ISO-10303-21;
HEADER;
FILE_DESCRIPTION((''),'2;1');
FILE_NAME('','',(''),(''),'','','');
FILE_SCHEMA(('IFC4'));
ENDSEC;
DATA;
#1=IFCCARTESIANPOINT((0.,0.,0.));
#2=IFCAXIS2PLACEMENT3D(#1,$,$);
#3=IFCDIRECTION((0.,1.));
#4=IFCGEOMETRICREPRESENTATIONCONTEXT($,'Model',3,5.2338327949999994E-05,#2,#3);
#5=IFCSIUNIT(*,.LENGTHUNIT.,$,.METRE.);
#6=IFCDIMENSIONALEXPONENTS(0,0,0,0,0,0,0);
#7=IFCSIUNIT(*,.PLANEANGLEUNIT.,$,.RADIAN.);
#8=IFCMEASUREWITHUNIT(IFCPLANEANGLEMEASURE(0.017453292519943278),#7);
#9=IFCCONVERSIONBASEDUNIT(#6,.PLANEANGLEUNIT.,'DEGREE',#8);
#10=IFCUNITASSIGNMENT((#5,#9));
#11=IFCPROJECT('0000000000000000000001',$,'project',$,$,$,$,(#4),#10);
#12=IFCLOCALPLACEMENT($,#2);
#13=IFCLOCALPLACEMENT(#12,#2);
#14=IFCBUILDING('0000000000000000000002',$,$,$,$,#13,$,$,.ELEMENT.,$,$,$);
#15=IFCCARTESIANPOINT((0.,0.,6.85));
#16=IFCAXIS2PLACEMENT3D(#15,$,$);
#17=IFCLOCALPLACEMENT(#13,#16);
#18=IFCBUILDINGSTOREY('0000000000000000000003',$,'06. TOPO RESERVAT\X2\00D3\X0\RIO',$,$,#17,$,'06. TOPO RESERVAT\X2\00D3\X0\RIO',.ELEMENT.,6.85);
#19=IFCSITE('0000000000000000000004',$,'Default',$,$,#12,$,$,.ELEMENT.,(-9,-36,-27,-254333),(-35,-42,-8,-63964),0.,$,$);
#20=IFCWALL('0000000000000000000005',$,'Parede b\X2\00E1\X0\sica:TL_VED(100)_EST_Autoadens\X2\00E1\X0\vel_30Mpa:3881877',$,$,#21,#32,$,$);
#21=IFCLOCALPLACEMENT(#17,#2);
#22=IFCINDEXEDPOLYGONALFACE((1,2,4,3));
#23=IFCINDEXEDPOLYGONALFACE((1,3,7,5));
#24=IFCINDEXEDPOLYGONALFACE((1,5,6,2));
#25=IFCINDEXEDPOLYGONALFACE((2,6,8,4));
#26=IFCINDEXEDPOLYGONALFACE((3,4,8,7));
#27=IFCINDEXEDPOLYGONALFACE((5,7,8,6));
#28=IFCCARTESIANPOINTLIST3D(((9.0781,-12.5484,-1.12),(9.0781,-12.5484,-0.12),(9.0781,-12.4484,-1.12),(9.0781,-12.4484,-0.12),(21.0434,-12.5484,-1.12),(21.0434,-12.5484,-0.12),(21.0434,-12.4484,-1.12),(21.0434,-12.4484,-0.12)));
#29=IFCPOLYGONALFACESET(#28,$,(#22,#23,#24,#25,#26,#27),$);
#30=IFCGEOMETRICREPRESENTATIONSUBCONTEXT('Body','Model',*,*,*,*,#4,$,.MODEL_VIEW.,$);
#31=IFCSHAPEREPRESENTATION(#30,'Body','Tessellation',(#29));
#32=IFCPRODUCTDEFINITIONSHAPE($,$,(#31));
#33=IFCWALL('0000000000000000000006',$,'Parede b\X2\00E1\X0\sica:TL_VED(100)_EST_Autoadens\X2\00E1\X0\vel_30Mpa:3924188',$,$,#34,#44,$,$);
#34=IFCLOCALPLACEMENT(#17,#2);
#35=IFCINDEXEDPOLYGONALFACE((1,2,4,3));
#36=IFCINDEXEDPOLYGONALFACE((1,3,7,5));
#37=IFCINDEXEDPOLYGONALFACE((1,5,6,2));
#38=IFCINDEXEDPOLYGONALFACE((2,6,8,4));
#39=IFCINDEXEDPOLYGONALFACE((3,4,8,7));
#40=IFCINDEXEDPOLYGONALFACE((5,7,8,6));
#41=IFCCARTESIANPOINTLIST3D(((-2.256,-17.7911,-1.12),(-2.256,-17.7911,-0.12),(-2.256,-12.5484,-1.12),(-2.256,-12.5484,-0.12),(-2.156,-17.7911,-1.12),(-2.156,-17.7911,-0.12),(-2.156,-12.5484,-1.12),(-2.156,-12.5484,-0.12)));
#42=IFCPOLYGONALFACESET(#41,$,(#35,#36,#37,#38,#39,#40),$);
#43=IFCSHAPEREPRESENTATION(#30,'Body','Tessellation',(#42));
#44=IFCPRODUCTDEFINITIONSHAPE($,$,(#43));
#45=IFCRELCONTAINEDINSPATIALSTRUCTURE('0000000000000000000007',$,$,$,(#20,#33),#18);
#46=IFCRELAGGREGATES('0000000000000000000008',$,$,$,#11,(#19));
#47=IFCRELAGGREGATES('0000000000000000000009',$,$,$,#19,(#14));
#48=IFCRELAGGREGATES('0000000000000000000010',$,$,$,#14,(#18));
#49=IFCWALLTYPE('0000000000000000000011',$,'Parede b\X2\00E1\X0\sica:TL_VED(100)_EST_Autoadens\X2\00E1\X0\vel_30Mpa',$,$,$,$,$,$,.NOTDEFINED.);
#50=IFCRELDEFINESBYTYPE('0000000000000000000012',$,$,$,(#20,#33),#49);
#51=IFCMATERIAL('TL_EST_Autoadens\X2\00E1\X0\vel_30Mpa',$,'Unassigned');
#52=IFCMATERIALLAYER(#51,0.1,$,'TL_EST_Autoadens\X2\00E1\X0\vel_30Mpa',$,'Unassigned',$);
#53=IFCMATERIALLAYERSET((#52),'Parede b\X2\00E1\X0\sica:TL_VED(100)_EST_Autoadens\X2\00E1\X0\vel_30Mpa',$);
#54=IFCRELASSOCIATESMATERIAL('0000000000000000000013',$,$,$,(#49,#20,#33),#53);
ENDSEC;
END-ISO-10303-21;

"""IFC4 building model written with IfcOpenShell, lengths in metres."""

from ifc_helpers import new_model, entity, si_unit, converted_unit, direction, frame, frame_2d, origin, place, context, subcontext, project, spatial, rectangle, extrude, material, layer, layer_set, layer_usage, type_object, element, save


model = new_model("IFC4")

# Units and contexts
model_context = context("Model", 3, precision=5.2338327949999994e-05, world=origin(), true_north=direction((0.0, 1.0)))
body_context = subcontext(model_context, "Body", "Model", "MODEL_VIEW")
ifc_project = project(units=[si_unit("LENGTHUNIT", "METRE"), converted_unit("PLANEANGLEUNIT", "DEGREE", entity("IfcPlaneAngleMeasure", 0.017453292519943278), si_unit("PLANEANGLEUNIT", "RADIAN"), dimensions=[0, 0, 0, 0, 0, 0, 0])], contexts=[model_context])

# Site, building, storey
site_placement = place(None, frame((0.0, 0.0, 0.0)))
site = spatial("IfcSite", under=ifc_project, at=site_placement, Name="Default", CompositionType="ELEMENT", RefLatitude=(-9, -36, -27, -254333), RefLongitude=(-35, -42, -8, -63964), RefElevation=0.0)
building_placement = place(site_placement, origin())
building = spatial("IfcBuilding", under=site, at=building_placement, CompositionType="ELEMENT")
storey_placement = place(building_placement, frame((0.0, 0.0, 6.85)))
storey = spatial("IfcBuildingStorey", under=building, at=storey_placement, Name="06. TOPO RESERVATÓRIO", LongName="06. TOPO RESERVATÓRIO", CompositionType="ELEMENT", Elevation=6.85)

# Walls
ifc_material_1 = material(Name="TL_EST_Autoadensável_30Mpa", Category="Unassigned")
ifc_layer_1 = layer(ifc_material_1, 0.1, Name="TL_EST_Autoadensável_30Mpa", Category="Unassigned")
ifc_layer_set_1 = layer_set([ifc_layer_1], Name="Parede básica:TL_VED(100)_EST_Autoadensável_30Mpa")
ifc_layer_usage_1 = layer_usage(ifc_layer_set_1, "AXIS2", "POSITIVE", -0.05)
wall_type = type_object("IfcWallType", Name="Parede básica:TL_VED(100)_EST_Autoadensável_30Mpa", PredefinedType="NOTDEFINED", material=ifc_layer_set_1)
wall_1_placement = place(storey_placement, frame((9.0781, -12.4984, -1.12)))
element("IfcWall", 1, at=wall_1_placement, inside=storey, type_object=wall_type, material=ifc_layer_usage_1, Name="Parede básica:TL_VED(100)_EST_Autoadensável_30Mpa:3881877", context=body_context, shape_type="SweptSolid", body=[
    extrude(rectangle(XDim=11.9653, YDim=0.1, at=frame_2d((5.9826, 0.0), x_axis=(-1.0, 0.0))), origin(), (0.0, 0.0, 1.0), 1.0),
])
ifc_layer_usage_2 = layer_usage(ifc_layer_set_1, "AXIS2", "NEGATIVE", 0.05)
wall_2_placement = place(storey_placement, frame((-2.206, -12.5484, -1.12), z_axis=(0.0, 0.0, 1.0), x_axis=(0.0, -1.0, 0.0)))
element("IfcWall", 2, at=wall_2_placement, inside=storey, type_object=wall_type, material=ifc_layer_usage_2, Name="Parede básica:TL_VED(100)_EST_Autoadensável_30Mpa:3924188", context=body_context, shape_type="SweptSolid", body=[
    extrude(rectangle(XDim=5.2427, YDim=0.1, at=frame_2d((2.6214, 0.0), x_axis=(-1.0, 0.0))), origin(), (0.0, 0.0, 1.0), 1.0),
])

save(model, "model.ifc")
